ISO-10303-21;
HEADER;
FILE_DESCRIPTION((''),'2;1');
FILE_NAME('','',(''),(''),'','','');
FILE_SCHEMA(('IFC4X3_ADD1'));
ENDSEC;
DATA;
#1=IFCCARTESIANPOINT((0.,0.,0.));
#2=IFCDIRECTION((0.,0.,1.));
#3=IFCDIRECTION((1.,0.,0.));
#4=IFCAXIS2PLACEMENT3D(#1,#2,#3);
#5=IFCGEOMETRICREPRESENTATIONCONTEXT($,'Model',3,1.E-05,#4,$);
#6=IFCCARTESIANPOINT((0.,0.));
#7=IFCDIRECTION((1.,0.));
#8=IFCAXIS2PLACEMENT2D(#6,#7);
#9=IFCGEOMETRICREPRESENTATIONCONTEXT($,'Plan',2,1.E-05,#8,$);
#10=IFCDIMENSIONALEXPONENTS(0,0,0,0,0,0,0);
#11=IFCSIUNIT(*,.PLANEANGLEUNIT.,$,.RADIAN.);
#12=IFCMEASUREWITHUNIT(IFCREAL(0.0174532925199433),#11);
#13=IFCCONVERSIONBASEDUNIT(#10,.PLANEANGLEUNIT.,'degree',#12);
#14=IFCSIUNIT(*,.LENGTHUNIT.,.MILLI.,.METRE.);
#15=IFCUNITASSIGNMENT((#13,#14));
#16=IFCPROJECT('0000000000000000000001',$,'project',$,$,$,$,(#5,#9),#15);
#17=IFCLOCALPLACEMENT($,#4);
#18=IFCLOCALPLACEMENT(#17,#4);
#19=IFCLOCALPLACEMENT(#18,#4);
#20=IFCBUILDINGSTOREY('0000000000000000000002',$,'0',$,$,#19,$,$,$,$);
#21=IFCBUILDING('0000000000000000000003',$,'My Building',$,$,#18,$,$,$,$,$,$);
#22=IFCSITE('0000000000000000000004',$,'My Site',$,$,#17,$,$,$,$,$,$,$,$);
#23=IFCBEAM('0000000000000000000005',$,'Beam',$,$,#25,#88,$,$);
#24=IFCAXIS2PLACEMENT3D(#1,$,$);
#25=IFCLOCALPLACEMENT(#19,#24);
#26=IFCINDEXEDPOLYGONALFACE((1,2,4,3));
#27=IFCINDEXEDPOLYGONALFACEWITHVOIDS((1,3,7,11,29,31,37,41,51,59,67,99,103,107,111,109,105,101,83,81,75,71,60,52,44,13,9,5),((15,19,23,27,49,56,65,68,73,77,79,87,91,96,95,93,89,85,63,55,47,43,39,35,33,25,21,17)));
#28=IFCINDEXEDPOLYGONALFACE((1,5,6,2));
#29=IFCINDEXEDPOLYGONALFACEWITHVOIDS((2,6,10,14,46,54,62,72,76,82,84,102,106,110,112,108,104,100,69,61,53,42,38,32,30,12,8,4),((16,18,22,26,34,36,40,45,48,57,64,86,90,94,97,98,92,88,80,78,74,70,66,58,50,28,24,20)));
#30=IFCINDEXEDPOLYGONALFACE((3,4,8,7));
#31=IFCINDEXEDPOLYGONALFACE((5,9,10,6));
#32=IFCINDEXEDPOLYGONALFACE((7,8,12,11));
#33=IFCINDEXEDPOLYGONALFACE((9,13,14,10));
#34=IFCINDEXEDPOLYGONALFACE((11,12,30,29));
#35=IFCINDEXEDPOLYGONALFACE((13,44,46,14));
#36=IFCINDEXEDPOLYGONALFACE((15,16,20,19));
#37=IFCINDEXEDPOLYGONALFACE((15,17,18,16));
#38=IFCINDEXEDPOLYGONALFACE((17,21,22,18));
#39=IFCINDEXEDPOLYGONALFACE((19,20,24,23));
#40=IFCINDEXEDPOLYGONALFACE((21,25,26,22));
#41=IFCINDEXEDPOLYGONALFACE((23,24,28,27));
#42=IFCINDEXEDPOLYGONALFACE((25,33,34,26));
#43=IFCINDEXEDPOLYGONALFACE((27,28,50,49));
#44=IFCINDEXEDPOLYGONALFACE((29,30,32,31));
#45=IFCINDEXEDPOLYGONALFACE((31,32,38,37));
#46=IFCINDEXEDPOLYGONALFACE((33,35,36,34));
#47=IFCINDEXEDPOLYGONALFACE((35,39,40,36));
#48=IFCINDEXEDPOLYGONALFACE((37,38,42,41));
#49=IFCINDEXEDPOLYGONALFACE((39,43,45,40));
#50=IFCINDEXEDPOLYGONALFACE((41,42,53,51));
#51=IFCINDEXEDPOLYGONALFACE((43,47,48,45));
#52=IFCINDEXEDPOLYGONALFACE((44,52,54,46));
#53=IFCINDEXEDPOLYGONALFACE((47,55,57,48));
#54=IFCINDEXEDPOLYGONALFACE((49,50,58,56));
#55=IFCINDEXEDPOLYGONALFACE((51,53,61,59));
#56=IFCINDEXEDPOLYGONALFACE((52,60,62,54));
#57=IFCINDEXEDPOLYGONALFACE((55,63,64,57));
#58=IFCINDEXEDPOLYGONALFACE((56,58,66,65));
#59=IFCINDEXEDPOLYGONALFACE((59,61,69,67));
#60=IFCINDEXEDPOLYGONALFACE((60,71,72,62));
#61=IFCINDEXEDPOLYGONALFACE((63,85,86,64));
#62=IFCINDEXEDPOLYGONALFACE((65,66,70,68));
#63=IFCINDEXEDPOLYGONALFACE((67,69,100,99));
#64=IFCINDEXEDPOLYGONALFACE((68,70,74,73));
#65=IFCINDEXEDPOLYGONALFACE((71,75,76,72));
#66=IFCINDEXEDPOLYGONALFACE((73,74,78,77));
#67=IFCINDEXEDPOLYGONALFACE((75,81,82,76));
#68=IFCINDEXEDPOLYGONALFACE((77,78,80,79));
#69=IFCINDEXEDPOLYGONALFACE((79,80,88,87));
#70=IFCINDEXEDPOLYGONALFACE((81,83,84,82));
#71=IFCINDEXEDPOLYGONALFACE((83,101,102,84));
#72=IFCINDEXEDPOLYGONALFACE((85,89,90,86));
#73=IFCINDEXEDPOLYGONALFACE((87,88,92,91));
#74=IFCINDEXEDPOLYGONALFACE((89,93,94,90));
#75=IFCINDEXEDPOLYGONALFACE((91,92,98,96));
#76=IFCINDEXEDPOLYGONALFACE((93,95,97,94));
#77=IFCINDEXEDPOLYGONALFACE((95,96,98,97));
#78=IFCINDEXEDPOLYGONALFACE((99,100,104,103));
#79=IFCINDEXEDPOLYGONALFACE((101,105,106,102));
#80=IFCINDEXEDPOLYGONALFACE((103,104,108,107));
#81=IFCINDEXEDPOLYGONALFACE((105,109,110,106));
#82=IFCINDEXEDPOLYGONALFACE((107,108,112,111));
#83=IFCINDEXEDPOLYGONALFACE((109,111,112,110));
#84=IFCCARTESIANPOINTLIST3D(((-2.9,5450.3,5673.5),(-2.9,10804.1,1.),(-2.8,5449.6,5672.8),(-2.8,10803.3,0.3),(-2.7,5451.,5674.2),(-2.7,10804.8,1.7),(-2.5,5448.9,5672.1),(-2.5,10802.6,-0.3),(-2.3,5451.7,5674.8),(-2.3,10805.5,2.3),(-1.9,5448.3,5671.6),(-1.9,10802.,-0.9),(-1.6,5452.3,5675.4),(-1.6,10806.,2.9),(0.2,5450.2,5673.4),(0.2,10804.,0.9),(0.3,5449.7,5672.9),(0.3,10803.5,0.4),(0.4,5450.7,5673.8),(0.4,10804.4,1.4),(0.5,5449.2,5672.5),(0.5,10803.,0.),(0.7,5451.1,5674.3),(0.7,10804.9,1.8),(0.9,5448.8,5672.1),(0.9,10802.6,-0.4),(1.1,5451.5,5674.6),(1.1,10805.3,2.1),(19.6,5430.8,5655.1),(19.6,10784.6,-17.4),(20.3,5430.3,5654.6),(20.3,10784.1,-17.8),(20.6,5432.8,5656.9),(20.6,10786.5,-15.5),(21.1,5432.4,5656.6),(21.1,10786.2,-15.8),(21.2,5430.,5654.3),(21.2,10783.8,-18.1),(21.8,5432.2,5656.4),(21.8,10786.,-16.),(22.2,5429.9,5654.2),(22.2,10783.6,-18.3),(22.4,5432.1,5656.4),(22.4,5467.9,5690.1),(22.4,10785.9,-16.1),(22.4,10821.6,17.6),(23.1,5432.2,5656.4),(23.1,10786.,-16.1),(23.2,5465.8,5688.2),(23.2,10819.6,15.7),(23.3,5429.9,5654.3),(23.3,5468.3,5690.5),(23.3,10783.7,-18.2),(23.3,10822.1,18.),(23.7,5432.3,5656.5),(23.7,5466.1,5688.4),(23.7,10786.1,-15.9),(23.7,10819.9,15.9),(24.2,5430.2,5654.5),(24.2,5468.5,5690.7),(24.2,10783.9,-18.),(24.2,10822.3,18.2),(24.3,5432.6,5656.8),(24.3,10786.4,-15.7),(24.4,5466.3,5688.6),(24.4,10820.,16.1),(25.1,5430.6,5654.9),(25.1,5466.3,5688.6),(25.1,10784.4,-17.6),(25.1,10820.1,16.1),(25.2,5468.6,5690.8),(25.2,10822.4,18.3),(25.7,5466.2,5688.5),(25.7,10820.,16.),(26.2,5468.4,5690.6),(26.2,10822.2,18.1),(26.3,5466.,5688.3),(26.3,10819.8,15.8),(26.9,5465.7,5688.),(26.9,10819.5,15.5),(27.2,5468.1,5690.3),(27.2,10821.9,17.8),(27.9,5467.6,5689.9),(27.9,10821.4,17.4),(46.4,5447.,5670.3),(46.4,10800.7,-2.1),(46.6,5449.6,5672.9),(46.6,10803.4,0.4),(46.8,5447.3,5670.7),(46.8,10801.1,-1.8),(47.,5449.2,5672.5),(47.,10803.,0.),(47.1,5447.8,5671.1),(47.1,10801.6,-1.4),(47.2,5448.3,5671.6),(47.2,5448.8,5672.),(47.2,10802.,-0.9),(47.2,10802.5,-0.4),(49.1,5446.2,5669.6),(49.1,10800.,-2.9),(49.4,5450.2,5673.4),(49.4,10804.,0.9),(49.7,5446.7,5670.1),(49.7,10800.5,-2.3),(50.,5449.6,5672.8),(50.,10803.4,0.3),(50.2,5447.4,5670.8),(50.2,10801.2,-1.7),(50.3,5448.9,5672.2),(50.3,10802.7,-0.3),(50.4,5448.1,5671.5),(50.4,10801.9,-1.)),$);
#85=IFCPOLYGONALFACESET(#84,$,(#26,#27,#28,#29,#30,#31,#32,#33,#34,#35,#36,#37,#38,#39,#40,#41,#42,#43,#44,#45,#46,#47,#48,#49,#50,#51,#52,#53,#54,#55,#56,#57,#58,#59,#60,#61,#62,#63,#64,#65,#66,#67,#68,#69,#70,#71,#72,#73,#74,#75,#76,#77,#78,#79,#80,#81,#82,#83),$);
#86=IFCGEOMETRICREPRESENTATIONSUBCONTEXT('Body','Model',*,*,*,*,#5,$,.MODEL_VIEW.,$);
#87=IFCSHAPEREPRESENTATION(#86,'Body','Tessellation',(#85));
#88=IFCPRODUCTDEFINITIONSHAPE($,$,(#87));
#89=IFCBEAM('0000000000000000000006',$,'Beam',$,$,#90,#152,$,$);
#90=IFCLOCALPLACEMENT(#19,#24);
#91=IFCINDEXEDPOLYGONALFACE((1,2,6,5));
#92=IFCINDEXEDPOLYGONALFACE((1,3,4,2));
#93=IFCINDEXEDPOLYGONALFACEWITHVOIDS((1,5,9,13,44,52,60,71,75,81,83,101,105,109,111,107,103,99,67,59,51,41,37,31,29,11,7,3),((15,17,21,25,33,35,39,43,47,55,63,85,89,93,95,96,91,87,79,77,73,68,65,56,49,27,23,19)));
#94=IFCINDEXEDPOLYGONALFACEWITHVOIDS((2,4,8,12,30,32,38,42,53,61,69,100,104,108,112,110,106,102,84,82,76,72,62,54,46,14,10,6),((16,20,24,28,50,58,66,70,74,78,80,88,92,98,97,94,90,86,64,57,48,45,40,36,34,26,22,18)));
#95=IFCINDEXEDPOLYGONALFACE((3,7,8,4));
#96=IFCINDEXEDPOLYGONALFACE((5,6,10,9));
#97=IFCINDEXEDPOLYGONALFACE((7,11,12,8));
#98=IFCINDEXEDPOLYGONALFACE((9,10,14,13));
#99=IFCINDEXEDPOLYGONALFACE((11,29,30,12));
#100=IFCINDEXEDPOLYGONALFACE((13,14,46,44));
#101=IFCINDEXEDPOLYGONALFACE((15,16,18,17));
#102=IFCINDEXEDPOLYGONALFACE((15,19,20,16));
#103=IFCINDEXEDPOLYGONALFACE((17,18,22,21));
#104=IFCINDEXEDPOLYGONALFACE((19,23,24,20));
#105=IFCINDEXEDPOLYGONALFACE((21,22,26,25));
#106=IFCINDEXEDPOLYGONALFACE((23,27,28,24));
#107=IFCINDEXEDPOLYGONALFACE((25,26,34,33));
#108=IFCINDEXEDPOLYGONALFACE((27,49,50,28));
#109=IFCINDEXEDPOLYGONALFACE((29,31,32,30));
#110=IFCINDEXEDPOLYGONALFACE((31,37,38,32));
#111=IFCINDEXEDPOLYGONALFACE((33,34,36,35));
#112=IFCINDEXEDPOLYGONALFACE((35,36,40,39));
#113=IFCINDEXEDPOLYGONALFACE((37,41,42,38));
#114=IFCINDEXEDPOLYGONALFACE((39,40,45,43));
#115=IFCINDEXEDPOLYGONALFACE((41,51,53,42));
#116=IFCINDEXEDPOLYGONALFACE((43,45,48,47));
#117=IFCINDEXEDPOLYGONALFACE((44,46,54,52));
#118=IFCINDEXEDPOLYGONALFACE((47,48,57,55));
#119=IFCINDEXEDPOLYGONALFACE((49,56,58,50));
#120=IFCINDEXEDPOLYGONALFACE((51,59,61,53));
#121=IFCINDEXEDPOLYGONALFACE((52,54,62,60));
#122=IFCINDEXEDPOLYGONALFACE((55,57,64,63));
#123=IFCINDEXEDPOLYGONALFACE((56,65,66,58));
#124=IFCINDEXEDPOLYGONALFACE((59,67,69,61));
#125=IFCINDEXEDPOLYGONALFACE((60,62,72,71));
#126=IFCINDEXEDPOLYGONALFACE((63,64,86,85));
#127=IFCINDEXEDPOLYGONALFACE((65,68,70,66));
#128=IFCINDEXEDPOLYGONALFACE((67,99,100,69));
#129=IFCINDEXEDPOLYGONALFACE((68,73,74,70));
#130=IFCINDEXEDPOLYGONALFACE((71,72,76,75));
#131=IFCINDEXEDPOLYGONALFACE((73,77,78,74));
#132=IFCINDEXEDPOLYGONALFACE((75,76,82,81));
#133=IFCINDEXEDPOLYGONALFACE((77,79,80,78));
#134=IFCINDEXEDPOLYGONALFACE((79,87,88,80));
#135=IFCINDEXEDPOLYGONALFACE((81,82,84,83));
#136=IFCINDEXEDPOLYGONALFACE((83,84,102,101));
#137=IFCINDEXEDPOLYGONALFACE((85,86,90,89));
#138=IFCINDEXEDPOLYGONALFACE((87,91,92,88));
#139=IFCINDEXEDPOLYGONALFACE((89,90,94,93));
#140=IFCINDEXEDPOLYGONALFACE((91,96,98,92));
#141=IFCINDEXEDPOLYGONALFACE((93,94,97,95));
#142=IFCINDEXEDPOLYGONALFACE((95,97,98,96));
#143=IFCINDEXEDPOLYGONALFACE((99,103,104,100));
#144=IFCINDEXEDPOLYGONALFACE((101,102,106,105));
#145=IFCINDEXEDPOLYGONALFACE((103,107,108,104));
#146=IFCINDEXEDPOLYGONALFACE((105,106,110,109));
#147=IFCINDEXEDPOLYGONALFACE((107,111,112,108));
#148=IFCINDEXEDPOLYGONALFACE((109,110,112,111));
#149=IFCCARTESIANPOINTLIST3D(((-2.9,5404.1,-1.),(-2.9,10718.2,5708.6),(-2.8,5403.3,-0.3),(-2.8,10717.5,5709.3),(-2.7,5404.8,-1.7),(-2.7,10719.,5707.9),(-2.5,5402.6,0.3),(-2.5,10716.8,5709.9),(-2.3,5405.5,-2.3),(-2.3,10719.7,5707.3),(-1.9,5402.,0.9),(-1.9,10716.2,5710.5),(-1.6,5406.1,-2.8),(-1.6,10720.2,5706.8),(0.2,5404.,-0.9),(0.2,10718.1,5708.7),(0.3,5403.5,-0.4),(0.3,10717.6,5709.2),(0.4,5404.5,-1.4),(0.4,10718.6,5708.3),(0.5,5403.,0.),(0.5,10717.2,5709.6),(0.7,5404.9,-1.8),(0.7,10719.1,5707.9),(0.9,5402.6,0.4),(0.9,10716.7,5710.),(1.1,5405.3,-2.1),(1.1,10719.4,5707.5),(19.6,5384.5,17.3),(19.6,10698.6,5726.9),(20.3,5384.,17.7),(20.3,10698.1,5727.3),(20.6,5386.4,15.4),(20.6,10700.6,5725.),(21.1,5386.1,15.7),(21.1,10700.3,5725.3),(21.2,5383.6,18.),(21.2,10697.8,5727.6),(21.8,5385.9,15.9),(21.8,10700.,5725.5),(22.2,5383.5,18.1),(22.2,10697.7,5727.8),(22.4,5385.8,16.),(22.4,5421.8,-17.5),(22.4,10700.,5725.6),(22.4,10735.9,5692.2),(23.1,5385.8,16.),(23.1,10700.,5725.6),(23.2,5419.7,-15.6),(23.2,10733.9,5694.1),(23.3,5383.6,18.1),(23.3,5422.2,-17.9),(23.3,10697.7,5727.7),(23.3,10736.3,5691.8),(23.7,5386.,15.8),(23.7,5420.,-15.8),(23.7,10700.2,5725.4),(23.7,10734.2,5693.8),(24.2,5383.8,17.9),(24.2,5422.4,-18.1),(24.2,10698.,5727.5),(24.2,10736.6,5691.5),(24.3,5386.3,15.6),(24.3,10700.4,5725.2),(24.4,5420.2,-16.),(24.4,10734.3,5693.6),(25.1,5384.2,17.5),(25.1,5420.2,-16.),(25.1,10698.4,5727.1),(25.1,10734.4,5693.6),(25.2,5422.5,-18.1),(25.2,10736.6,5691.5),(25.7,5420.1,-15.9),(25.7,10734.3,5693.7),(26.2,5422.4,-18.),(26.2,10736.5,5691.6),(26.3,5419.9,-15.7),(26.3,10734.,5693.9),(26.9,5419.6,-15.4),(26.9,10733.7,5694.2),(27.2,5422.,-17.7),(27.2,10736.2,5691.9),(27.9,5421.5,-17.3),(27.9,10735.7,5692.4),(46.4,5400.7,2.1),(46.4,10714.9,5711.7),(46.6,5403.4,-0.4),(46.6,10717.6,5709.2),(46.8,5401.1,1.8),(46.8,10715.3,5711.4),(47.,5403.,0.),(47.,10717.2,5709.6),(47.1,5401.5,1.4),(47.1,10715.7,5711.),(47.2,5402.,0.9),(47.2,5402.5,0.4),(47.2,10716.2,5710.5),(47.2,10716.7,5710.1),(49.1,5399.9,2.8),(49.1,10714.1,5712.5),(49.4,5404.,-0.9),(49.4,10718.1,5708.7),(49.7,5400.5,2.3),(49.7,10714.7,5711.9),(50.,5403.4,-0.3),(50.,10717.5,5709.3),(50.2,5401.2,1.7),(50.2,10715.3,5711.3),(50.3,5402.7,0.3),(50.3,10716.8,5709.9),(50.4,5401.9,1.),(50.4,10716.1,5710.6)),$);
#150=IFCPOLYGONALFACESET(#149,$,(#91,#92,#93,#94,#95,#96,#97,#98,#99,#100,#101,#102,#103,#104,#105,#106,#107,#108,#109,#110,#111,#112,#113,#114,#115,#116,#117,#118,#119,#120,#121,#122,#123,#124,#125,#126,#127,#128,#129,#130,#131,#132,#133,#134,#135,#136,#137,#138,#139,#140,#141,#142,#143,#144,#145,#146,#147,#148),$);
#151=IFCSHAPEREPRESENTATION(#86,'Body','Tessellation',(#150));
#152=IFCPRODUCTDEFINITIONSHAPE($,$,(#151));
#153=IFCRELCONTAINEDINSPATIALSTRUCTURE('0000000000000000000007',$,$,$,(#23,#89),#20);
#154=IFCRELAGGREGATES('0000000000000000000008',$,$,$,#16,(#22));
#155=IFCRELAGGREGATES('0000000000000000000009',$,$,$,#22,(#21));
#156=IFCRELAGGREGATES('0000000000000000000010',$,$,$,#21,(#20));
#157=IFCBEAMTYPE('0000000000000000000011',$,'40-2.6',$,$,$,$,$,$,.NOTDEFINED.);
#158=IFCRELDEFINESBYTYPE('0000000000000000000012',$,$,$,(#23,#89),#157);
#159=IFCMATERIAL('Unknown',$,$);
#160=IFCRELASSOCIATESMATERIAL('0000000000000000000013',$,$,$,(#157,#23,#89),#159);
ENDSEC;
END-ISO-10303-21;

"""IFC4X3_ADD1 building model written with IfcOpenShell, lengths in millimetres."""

from ifc_helpers import new_model, entity, si_unit, converted_unit, frame, origin_with_axes, origin_2d_with_axis, place, context, subcontext, project, spatial, hollow_rectangle, extrude, material, material_profile, profile_set, profile_usage, type_object, element, save


model = new_model("IFC4X3_ADD1")

# Units and contexts
model_context = context("Model", 3, precision=1e-05, world=origin_with_axes())
plan_context = context("Plan", 2, precision=1e-05, world=origin_2d_with_axis())
body_context = subcontext(model_context, "Body", "Model", "MODEL_VIEW")
ifc_project = project(units=[converted_unit("PLANEANGLEUNIT", "degree", entity("IfcReal", 0.0174532925199433), si_unit("PLANEANGLEUNIT", "RADIAN"), dimensions=[0, 0, 0, 0, 0, 0, 0]), si_unit("LENGTHUNIT", "METRE", prefix="MILLI")], contexts=[model_context, plan_context])

# Site, building, storey
site_placement = place(None, origin_with_axes())
site = spatial("IfcSite", under=ifc_project, at=site_placement, Name="My Site")
building_placement = place(site_placement, origin_with_axes())
building = spatial("IfcBuilding", under=site, at=building_placement, Name="My Building")
storey_placement = place(building_placement, origin_with_axes())
storey = spatial("IfcBuildingStorey", under=building, at=storey_placement, Name="0")

# Shared definitions
ifc_material = material(Name="Unknown")

# Beams
ifc_material_profile_1 = material_profile(ifc_material, hollow_rectangle(XDim=40.0, YDim=40.0, WallThickness=2.6, InnerFilletRadius=2.6, OuterFilletRadius=3.9))
ifc_profile_set_1 = profile_set([ifc_material_profile_1])
beam_type = type_object("IfcBeamType", Name="40-2.6", PredefinedType="NOTDEFINED", material=ifc_profile_set_1)
ifc_profile_usage_1 = profile_usage(ifc_profile_set_1, cardinal=5)
beam_1_placement = place(storey_placement, frame((23.7, 10803.0, 0.0), z_axis=(0.0, -0.686382, 0.727241), x_axis=(-0.666409, 0.542221, 0.511757)))
element("IfcBeam", 1, at=beam_1_placement, inside=storey, type_object=beam_type, material=ifc_profile_usage_1, Name="Beam", context=body_context, shape_type="SweptSolid", body=[
    extrude(hollow_rectangle(XDim=40.0, YDim=40.0, WallThickness=2.6, InnerFilletRadius=2.6, OuterFilletRadius=3.9), origin_with_axes(), (0.0, 0.0, 1.0), 7800.0),
])
ifc_profile_usage_2 = profile_usage(ifc_profile_set_1, cardinal=5)
beam_2_placement = place(storey_placement, frame((23.7, 5403.0, 0.0), z_axis=(0.0, 0.681302, 0.732003), x_axis=(-0.666409, 0.545771, -0.507969)))
element("IfcBeam", 2, at=beam_2_placement, inside=storey, type_object=beam_type, material=ifc_profile_usage_2, Name="Beam", context=body_context, shape_type="SweptSolid", body=[
    extrude(hollow_rectangle(XDim=40.0, YDim=40.0, WallThickness=2.6, InnerFilletRadius=2.6, OuterFilletRadius=3.9), origin_with_axes(), (0.0, 0.0, 1.0), 7800.0),
])

save(model, "model.ifc")
